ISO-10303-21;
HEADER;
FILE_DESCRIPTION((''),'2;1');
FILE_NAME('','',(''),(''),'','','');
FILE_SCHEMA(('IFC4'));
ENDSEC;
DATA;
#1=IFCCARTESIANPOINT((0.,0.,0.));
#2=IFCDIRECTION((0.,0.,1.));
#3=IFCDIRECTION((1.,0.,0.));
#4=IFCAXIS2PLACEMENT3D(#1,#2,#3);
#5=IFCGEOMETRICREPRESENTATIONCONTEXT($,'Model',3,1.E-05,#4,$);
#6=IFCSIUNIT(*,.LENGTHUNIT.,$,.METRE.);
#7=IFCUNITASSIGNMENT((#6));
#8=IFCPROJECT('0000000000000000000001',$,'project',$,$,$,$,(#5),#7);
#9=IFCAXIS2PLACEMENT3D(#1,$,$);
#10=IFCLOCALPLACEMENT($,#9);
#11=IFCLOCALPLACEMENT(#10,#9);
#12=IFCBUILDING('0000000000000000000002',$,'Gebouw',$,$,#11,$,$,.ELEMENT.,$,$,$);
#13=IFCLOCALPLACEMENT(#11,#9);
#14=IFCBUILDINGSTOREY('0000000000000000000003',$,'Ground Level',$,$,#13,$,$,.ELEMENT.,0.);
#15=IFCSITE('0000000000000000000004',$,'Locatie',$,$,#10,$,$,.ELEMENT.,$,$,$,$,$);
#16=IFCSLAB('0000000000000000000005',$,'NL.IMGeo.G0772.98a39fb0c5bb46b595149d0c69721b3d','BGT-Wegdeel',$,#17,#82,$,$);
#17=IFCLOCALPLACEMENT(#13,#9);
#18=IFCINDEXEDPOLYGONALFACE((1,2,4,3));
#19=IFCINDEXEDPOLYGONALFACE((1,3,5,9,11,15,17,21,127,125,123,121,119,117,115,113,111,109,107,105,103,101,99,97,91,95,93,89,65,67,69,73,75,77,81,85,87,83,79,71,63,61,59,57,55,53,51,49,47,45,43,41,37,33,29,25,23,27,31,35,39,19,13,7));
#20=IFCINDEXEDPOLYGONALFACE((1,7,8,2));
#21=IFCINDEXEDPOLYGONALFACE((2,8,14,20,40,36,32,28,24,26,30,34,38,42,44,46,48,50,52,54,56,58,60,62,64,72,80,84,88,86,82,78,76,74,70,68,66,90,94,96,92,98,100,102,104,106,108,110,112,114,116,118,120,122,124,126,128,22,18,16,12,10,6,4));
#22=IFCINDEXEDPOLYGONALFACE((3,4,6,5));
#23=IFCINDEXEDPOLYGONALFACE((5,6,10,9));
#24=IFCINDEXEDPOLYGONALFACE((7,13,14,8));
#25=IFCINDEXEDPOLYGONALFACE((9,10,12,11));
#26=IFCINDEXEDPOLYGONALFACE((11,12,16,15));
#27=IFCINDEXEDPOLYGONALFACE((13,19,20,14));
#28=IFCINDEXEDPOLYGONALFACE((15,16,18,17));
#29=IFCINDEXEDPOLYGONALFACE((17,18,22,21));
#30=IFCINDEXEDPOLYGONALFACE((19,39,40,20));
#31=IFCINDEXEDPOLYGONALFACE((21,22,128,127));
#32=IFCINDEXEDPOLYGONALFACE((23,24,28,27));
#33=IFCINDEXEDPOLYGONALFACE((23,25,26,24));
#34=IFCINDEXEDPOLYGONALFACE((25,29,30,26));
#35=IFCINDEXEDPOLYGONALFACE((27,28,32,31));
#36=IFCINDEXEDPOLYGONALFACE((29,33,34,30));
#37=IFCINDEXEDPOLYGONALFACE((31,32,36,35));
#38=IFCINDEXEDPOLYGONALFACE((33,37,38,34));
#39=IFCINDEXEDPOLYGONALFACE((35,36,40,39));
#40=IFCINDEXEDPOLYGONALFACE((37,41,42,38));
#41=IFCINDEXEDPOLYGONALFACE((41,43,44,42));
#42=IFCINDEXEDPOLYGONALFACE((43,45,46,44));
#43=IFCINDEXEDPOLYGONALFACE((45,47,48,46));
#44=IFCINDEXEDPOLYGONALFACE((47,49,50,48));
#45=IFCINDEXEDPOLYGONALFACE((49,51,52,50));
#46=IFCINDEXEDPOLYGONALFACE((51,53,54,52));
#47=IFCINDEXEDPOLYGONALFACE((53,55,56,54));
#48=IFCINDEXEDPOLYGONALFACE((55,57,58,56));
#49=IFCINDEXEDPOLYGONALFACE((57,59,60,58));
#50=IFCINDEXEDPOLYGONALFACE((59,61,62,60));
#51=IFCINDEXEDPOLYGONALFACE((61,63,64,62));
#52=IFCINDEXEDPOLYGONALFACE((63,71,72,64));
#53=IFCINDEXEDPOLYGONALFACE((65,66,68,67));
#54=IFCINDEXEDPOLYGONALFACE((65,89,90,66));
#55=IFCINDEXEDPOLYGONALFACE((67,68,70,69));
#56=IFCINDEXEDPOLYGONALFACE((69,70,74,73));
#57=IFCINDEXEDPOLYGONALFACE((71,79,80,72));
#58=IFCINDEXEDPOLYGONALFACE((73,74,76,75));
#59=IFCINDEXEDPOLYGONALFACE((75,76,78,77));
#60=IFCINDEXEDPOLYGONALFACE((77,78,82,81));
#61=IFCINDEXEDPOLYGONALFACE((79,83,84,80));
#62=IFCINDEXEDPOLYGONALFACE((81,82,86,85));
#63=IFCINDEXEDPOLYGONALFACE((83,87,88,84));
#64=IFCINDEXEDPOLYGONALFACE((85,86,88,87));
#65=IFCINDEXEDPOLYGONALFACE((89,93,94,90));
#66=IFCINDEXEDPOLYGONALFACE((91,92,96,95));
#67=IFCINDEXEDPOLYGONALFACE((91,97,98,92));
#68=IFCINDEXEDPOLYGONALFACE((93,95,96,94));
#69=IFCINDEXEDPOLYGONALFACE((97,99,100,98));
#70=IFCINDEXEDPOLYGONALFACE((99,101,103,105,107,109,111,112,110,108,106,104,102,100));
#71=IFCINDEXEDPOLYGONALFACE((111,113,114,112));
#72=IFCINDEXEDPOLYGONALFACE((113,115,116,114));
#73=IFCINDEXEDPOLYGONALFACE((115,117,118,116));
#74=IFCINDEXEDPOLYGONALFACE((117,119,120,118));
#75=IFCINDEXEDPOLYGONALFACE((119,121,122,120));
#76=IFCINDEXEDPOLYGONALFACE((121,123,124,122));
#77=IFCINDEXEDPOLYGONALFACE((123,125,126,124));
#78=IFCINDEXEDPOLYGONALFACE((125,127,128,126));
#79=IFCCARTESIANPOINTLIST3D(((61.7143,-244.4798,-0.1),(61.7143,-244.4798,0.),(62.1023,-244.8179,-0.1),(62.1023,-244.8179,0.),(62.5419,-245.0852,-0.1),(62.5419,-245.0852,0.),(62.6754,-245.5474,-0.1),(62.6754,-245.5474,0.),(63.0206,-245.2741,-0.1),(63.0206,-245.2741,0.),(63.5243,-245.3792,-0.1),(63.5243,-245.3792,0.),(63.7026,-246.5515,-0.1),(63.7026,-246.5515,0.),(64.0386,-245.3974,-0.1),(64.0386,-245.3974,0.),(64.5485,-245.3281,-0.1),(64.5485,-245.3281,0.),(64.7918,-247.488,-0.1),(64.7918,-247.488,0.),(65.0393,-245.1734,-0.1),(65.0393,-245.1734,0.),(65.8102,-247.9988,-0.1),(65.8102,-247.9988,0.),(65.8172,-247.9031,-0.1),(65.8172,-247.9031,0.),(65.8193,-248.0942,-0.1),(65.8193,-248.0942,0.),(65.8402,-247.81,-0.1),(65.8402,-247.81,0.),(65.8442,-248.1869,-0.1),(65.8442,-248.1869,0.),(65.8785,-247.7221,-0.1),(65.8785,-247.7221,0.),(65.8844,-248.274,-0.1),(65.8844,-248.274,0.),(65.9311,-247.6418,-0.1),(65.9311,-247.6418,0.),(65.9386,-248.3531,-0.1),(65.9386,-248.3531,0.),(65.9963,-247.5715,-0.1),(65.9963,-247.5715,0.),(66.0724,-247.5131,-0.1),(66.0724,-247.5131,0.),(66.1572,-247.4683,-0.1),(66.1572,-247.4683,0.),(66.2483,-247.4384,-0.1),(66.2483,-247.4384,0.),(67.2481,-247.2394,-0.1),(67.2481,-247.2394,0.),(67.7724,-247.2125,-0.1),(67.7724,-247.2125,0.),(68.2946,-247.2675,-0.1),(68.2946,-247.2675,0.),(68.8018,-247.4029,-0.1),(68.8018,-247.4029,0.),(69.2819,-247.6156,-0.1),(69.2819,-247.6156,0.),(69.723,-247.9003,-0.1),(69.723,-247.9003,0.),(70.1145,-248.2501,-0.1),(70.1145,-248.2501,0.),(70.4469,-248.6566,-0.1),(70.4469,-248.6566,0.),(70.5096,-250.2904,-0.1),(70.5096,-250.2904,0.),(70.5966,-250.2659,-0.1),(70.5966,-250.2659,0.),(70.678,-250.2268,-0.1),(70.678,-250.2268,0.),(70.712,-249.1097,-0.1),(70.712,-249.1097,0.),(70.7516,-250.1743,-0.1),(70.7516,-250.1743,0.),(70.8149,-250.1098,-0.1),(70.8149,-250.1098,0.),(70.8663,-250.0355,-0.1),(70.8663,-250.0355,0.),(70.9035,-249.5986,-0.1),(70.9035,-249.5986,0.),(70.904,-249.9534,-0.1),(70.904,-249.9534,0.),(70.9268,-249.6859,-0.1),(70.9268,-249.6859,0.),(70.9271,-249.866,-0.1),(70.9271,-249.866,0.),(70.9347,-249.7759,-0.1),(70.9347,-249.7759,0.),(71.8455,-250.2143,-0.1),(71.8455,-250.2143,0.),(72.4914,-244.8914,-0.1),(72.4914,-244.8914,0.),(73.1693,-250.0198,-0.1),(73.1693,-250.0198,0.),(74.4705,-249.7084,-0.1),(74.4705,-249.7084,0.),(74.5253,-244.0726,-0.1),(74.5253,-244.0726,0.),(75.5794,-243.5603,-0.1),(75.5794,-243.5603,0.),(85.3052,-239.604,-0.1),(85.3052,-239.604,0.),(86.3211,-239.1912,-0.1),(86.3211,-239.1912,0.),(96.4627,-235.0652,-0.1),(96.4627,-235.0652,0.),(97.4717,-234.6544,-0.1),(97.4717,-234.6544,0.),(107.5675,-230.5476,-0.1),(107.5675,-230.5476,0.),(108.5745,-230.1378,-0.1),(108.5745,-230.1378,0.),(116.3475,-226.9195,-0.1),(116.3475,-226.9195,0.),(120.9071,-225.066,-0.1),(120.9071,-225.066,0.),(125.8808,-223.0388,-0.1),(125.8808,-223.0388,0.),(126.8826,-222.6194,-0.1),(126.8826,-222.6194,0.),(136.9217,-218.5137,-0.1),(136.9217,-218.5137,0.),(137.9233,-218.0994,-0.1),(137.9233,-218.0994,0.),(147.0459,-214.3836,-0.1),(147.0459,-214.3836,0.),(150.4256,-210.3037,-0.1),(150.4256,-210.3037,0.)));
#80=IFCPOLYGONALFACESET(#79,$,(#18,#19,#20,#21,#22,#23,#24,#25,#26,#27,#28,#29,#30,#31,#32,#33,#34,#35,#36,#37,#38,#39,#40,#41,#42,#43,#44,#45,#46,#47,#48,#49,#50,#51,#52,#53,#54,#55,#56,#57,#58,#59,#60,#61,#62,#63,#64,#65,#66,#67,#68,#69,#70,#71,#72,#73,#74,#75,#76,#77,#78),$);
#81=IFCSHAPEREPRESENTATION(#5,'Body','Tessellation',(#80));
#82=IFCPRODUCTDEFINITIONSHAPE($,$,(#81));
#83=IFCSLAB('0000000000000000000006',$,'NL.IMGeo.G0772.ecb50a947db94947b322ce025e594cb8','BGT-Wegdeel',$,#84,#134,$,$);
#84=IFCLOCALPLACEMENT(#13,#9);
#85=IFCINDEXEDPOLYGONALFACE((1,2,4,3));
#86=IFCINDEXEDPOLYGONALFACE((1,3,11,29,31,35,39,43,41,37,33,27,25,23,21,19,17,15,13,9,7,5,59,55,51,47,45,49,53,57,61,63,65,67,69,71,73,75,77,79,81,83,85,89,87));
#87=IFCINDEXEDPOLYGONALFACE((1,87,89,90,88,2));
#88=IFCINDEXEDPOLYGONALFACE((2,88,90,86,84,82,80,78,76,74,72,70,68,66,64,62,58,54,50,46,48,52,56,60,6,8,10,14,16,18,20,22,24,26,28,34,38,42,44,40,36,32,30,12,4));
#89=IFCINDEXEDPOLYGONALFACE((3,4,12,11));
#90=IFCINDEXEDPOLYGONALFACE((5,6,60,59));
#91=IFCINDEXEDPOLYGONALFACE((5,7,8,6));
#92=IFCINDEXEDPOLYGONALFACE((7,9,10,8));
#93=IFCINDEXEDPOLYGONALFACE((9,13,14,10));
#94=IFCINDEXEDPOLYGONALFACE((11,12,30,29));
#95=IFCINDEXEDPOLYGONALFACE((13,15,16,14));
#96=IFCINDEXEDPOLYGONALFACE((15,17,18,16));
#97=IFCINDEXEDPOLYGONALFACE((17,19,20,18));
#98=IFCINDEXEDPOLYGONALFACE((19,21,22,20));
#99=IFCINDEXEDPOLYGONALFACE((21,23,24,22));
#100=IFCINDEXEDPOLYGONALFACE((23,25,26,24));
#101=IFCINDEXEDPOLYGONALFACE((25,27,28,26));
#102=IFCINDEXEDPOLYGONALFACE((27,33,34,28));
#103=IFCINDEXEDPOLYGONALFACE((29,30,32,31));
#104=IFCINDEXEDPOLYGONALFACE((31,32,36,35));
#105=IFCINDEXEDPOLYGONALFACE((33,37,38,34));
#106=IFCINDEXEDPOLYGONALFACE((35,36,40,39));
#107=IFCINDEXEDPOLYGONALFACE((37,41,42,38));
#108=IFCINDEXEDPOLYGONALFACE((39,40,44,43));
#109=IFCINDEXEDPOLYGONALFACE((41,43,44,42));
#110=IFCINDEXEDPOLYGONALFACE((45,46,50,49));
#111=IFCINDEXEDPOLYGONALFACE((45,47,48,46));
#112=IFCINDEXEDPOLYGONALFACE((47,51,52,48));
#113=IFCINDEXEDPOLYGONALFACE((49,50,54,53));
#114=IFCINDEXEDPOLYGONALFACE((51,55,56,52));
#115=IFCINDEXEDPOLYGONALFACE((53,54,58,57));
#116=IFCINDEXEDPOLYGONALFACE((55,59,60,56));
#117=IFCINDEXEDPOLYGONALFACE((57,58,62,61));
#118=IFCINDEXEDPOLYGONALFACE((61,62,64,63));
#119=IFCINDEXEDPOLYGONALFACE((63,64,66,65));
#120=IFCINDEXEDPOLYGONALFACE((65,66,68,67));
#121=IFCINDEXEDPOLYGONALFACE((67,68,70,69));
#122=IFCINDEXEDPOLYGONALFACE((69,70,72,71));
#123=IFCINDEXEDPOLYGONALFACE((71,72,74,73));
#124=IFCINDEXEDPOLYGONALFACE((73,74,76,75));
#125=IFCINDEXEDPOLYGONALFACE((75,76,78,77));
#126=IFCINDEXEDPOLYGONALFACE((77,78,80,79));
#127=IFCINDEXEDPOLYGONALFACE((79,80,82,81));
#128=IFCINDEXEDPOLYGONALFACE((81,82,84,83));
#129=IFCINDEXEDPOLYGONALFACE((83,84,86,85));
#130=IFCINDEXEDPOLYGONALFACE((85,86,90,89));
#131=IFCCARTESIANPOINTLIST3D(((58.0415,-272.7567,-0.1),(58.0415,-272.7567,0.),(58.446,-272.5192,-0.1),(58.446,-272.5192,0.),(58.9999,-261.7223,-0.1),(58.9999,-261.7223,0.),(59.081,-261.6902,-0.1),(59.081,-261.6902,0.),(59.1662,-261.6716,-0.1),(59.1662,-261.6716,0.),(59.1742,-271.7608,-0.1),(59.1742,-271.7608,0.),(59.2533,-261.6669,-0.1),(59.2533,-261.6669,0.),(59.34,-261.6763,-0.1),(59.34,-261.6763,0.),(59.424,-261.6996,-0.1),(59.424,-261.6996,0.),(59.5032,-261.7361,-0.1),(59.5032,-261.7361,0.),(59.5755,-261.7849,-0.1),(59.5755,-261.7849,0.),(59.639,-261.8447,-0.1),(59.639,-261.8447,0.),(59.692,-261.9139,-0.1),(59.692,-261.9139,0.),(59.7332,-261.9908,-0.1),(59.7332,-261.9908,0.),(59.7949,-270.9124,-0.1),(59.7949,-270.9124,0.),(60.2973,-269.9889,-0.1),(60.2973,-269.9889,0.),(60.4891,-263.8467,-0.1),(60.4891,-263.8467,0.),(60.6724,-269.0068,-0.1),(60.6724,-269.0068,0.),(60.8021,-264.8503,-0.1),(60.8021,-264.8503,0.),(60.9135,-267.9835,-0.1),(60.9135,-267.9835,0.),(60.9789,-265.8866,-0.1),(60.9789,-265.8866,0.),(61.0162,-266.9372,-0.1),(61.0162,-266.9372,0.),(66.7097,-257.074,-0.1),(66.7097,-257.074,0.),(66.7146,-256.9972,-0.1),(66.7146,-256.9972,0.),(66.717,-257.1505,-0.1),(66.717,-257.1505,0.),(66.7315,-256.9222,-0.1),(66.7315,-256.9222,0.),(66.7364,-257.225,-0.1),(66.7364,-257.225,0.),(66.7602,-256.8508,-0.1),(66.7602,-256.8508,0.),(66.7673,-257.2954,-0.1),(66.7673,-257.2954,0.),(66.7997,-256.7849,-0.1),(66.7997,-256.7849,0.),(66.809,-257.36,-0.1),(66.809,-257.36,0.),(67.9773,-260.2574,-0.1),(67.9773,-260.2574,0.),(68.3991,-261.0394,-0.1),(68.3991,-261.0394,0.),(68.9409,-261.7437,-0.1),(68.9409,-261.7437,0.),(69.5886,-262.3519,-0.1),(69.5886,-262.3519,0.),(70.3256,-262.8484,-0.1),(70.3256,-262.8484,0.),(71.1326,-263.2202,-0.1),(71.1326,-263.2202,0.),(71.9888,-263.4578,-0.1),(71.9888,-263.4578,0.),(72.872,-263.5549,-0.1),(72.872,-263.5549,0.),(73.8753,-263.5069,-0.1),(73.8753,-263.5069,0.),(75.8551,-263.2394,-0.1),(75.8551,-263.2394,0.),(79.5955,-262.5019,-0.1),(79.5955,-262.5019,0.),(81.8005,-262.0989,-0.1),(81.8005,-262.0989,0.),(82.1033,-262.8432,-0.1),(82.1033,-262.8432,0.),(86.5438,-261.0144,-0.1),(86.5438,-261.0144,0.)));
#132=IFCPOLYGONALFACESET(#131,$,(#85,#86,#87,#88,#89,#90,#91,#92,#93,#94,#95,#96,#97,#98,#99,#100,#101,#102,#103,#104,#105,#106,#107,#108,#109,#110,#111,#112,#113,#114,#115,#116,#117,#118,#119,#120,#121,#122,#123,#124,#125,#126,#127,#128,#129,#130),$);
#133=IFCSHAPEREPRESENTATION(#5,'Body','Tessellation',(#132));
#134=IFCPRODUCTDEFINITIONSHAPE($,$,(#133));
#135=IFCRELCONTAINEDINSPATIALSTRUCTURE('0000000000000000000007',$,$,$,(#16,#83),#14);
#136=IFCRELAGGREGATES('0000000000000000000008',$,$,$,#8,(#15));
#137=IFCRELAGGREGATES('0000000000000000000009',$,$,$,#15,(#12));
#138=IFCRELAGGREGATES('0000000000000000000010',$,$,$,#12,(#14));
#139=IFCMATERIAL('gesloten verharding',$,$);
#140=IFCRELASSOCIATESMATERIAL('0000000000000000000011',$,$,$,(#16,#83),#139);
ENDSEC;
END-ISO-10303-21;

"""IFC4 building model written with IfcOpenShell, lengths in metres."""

from ifc_helpers import new_model, si_unit, frame, origin, origin_with_axes, place, context, project, spatial, polyline, outline, extrude, material, element, save


model = new_model("IFC4")

# Units and contexts
model_context = context("Model", 3, precision=1e-05, world=origin_with_axes())
ifc_project = project(units=[si_unit("LENGTHUNIT", "METRE")], contexts=[model_context])

# Site, building, storey
site_placement = place(None, origin())
site = spatial("IfcSite", under=ifc_project, at=site_placement, Name="Locatie", CompositionType="ELEMENT")
building_placement = place(site_placement, origin())
building = spatial("IfcBuilding", under=site, at=building_placement, Name="Gebouw", CompositionType="ELEMENT")
storey_placement = place(building_placement, origin())
storey = spatial("IfcBuildingStorey", under=building, at=storey_placement, Name="Ground Level", CompositionType="ELEMENT", Elevation=0.0)

# Slabs
ifc_material_1 = material(Name="gesloten verharding")
slab_1_placement = place(storey_placement, origin())
element("IfcSlab", 1, at=slab_1_placement, inside=storey, material=ifc_material_1, Name="NL.IMGeo.G0772.98a39fb0c5bb46b595149d0c69721b3d", Description="BGT-Wegdeel", context=model_context, shape_type="SweptSolid", body=[
    extrude(outline(polyline([(137.9233, -218.0994), (136.9217, -218.5137), (126.8826, -222.6194), (125.8808, -223.0388), (120.9071, -225.066), (116.3475, -226.9195), (108.5745, -230.1378), (107.5675, -230.5476), (97.4717, -234.6544), (96.4627, -235.0652), (86.3211, -239.1912), (85.3052, -239.604), (75.5794, -243.5603), (74.5253, -244.0726), (72.4914, -244.8914), (74.4705, -249.7084), (73.1693, -250.0198), (71.8455, -250.2143), (70.5096, -250.2904), (70.5966, -250.2659), (70.678, -250.2268), (70.7516, -250.1743), (70.8149, -250.1098), (70.8663, -250.0355), (70.904, -249.9534), (70.9271, -249.866), (70.9347, -249.7759), (70.9268, -249.6859), (70.9035, -249.5986), (70.712, -249.1097), (70.4469, -248.6566), (70.1145, -248.2501), (69.723, -247.9003), (69.2819, -247.6156), (68.8018, -247.4029), (68.2946, -247.2675), (67.7724, -247.2125), (67.2481, -247.2394), (66.2483, -247.4384), (66.1572, -247.4683), (66.0724, -247.5131), (65.9963, -247.5715), (65.9311, -247.6418), (65.8785, -247.7221), (65.8402, -247.81), (65.8172, -247.9031), (65.8102, -247.9988), (65.8193, -248.0942), (65.8442, -248.1869), (65.8844, -248.274), (65.9386, -248.3531), (64.7918, -247.488), (63.7026, -246.5515), (62.6754, -245.5474), (61.7143, -244.4798), (62.1023, -244.8179), (62.5419, -245.0852), (63.0206, -245.2741), (63.5243, -245.3792), (64.0386, -245.3974), (64.5485, -245.3281), (65.0393, -245.1734), (150.4256, -210.3037), (147.0459, -214.3836), (137.9233, -218.0994)])), frame((0.0, 0.0, -0.1), z_axis=(0.0, 0.0, 1.0), x_axis=(1.0, 0.0, 0.0)), (0.0, 0.0, 1.0), 0.1),
])
slab_2_placement = place(storey_placement, origin())
element("IfcSlab", 2, at=slab_2_placement, inside=storey, material=ifc_material_1, Name="NL.IMGeo.G0772.ecb50a947db94947b322ce025e594cb8", Description="BGT-Wegdeel", context=model_context, shape_type="SweptSolid", body=[
    extrude(outline(polyline([(67.9773, -260.2574), (68.3991, -261.0394), (68.9409, -261.7437), (69.5886, -262.3519), (70.3256, -262.8484), (71.1326, -263.2202), (71.9888, -263.4578), (72.872, -263.5549), (73.8753, -263.5069), (75.8551, -263.2394), (79.5955, -262.5019), (81.8005, -262.0989), (86.5438, -261.0144), (82.1033, -262.8432), (58.0415, -272.7567), (58.446, -272.5192), (59.1742, -271.7608), (59.7949, -270.9124), (60.2973, -269.9889), (60.6724, -269.0068), (60.9135, -267.9835), (61.0162, -266.9372), (60.9789, -265.8866), (60.8021, -264.8503), (60.4891, -263.8467), (59.7332, -261.9908), (59.692, -261.9139), (59.639, -261.8447), (59.5755, -261.7849), (59.5032, -261.7361), (59.424, -261.6996), (59.34, -261.6763), (59.2533, -261.6669), (59.1662, -261.6716), (59.081, -261.6902), (58.9999, -261.7223), (66.7997, -256.7849), (66.7602, -256.8508), (66.7315, -256.9222), (66.7146, -256.9972), (66.7097, -257.074), (66.717, -257.1505), (66.7364, -257.225), (66.7673, -257.2954), (66.809, -257.36), (67.9773, -260.2574)])), frame((0.0, 0.0, -0.1), z_axis=(0.0, 0.0, 1.0), x_axis=(1.0, 0.0, 0.0)), (0.0, 0.0, 1.0), 0.1),
])

save(model, "model.ifc")
